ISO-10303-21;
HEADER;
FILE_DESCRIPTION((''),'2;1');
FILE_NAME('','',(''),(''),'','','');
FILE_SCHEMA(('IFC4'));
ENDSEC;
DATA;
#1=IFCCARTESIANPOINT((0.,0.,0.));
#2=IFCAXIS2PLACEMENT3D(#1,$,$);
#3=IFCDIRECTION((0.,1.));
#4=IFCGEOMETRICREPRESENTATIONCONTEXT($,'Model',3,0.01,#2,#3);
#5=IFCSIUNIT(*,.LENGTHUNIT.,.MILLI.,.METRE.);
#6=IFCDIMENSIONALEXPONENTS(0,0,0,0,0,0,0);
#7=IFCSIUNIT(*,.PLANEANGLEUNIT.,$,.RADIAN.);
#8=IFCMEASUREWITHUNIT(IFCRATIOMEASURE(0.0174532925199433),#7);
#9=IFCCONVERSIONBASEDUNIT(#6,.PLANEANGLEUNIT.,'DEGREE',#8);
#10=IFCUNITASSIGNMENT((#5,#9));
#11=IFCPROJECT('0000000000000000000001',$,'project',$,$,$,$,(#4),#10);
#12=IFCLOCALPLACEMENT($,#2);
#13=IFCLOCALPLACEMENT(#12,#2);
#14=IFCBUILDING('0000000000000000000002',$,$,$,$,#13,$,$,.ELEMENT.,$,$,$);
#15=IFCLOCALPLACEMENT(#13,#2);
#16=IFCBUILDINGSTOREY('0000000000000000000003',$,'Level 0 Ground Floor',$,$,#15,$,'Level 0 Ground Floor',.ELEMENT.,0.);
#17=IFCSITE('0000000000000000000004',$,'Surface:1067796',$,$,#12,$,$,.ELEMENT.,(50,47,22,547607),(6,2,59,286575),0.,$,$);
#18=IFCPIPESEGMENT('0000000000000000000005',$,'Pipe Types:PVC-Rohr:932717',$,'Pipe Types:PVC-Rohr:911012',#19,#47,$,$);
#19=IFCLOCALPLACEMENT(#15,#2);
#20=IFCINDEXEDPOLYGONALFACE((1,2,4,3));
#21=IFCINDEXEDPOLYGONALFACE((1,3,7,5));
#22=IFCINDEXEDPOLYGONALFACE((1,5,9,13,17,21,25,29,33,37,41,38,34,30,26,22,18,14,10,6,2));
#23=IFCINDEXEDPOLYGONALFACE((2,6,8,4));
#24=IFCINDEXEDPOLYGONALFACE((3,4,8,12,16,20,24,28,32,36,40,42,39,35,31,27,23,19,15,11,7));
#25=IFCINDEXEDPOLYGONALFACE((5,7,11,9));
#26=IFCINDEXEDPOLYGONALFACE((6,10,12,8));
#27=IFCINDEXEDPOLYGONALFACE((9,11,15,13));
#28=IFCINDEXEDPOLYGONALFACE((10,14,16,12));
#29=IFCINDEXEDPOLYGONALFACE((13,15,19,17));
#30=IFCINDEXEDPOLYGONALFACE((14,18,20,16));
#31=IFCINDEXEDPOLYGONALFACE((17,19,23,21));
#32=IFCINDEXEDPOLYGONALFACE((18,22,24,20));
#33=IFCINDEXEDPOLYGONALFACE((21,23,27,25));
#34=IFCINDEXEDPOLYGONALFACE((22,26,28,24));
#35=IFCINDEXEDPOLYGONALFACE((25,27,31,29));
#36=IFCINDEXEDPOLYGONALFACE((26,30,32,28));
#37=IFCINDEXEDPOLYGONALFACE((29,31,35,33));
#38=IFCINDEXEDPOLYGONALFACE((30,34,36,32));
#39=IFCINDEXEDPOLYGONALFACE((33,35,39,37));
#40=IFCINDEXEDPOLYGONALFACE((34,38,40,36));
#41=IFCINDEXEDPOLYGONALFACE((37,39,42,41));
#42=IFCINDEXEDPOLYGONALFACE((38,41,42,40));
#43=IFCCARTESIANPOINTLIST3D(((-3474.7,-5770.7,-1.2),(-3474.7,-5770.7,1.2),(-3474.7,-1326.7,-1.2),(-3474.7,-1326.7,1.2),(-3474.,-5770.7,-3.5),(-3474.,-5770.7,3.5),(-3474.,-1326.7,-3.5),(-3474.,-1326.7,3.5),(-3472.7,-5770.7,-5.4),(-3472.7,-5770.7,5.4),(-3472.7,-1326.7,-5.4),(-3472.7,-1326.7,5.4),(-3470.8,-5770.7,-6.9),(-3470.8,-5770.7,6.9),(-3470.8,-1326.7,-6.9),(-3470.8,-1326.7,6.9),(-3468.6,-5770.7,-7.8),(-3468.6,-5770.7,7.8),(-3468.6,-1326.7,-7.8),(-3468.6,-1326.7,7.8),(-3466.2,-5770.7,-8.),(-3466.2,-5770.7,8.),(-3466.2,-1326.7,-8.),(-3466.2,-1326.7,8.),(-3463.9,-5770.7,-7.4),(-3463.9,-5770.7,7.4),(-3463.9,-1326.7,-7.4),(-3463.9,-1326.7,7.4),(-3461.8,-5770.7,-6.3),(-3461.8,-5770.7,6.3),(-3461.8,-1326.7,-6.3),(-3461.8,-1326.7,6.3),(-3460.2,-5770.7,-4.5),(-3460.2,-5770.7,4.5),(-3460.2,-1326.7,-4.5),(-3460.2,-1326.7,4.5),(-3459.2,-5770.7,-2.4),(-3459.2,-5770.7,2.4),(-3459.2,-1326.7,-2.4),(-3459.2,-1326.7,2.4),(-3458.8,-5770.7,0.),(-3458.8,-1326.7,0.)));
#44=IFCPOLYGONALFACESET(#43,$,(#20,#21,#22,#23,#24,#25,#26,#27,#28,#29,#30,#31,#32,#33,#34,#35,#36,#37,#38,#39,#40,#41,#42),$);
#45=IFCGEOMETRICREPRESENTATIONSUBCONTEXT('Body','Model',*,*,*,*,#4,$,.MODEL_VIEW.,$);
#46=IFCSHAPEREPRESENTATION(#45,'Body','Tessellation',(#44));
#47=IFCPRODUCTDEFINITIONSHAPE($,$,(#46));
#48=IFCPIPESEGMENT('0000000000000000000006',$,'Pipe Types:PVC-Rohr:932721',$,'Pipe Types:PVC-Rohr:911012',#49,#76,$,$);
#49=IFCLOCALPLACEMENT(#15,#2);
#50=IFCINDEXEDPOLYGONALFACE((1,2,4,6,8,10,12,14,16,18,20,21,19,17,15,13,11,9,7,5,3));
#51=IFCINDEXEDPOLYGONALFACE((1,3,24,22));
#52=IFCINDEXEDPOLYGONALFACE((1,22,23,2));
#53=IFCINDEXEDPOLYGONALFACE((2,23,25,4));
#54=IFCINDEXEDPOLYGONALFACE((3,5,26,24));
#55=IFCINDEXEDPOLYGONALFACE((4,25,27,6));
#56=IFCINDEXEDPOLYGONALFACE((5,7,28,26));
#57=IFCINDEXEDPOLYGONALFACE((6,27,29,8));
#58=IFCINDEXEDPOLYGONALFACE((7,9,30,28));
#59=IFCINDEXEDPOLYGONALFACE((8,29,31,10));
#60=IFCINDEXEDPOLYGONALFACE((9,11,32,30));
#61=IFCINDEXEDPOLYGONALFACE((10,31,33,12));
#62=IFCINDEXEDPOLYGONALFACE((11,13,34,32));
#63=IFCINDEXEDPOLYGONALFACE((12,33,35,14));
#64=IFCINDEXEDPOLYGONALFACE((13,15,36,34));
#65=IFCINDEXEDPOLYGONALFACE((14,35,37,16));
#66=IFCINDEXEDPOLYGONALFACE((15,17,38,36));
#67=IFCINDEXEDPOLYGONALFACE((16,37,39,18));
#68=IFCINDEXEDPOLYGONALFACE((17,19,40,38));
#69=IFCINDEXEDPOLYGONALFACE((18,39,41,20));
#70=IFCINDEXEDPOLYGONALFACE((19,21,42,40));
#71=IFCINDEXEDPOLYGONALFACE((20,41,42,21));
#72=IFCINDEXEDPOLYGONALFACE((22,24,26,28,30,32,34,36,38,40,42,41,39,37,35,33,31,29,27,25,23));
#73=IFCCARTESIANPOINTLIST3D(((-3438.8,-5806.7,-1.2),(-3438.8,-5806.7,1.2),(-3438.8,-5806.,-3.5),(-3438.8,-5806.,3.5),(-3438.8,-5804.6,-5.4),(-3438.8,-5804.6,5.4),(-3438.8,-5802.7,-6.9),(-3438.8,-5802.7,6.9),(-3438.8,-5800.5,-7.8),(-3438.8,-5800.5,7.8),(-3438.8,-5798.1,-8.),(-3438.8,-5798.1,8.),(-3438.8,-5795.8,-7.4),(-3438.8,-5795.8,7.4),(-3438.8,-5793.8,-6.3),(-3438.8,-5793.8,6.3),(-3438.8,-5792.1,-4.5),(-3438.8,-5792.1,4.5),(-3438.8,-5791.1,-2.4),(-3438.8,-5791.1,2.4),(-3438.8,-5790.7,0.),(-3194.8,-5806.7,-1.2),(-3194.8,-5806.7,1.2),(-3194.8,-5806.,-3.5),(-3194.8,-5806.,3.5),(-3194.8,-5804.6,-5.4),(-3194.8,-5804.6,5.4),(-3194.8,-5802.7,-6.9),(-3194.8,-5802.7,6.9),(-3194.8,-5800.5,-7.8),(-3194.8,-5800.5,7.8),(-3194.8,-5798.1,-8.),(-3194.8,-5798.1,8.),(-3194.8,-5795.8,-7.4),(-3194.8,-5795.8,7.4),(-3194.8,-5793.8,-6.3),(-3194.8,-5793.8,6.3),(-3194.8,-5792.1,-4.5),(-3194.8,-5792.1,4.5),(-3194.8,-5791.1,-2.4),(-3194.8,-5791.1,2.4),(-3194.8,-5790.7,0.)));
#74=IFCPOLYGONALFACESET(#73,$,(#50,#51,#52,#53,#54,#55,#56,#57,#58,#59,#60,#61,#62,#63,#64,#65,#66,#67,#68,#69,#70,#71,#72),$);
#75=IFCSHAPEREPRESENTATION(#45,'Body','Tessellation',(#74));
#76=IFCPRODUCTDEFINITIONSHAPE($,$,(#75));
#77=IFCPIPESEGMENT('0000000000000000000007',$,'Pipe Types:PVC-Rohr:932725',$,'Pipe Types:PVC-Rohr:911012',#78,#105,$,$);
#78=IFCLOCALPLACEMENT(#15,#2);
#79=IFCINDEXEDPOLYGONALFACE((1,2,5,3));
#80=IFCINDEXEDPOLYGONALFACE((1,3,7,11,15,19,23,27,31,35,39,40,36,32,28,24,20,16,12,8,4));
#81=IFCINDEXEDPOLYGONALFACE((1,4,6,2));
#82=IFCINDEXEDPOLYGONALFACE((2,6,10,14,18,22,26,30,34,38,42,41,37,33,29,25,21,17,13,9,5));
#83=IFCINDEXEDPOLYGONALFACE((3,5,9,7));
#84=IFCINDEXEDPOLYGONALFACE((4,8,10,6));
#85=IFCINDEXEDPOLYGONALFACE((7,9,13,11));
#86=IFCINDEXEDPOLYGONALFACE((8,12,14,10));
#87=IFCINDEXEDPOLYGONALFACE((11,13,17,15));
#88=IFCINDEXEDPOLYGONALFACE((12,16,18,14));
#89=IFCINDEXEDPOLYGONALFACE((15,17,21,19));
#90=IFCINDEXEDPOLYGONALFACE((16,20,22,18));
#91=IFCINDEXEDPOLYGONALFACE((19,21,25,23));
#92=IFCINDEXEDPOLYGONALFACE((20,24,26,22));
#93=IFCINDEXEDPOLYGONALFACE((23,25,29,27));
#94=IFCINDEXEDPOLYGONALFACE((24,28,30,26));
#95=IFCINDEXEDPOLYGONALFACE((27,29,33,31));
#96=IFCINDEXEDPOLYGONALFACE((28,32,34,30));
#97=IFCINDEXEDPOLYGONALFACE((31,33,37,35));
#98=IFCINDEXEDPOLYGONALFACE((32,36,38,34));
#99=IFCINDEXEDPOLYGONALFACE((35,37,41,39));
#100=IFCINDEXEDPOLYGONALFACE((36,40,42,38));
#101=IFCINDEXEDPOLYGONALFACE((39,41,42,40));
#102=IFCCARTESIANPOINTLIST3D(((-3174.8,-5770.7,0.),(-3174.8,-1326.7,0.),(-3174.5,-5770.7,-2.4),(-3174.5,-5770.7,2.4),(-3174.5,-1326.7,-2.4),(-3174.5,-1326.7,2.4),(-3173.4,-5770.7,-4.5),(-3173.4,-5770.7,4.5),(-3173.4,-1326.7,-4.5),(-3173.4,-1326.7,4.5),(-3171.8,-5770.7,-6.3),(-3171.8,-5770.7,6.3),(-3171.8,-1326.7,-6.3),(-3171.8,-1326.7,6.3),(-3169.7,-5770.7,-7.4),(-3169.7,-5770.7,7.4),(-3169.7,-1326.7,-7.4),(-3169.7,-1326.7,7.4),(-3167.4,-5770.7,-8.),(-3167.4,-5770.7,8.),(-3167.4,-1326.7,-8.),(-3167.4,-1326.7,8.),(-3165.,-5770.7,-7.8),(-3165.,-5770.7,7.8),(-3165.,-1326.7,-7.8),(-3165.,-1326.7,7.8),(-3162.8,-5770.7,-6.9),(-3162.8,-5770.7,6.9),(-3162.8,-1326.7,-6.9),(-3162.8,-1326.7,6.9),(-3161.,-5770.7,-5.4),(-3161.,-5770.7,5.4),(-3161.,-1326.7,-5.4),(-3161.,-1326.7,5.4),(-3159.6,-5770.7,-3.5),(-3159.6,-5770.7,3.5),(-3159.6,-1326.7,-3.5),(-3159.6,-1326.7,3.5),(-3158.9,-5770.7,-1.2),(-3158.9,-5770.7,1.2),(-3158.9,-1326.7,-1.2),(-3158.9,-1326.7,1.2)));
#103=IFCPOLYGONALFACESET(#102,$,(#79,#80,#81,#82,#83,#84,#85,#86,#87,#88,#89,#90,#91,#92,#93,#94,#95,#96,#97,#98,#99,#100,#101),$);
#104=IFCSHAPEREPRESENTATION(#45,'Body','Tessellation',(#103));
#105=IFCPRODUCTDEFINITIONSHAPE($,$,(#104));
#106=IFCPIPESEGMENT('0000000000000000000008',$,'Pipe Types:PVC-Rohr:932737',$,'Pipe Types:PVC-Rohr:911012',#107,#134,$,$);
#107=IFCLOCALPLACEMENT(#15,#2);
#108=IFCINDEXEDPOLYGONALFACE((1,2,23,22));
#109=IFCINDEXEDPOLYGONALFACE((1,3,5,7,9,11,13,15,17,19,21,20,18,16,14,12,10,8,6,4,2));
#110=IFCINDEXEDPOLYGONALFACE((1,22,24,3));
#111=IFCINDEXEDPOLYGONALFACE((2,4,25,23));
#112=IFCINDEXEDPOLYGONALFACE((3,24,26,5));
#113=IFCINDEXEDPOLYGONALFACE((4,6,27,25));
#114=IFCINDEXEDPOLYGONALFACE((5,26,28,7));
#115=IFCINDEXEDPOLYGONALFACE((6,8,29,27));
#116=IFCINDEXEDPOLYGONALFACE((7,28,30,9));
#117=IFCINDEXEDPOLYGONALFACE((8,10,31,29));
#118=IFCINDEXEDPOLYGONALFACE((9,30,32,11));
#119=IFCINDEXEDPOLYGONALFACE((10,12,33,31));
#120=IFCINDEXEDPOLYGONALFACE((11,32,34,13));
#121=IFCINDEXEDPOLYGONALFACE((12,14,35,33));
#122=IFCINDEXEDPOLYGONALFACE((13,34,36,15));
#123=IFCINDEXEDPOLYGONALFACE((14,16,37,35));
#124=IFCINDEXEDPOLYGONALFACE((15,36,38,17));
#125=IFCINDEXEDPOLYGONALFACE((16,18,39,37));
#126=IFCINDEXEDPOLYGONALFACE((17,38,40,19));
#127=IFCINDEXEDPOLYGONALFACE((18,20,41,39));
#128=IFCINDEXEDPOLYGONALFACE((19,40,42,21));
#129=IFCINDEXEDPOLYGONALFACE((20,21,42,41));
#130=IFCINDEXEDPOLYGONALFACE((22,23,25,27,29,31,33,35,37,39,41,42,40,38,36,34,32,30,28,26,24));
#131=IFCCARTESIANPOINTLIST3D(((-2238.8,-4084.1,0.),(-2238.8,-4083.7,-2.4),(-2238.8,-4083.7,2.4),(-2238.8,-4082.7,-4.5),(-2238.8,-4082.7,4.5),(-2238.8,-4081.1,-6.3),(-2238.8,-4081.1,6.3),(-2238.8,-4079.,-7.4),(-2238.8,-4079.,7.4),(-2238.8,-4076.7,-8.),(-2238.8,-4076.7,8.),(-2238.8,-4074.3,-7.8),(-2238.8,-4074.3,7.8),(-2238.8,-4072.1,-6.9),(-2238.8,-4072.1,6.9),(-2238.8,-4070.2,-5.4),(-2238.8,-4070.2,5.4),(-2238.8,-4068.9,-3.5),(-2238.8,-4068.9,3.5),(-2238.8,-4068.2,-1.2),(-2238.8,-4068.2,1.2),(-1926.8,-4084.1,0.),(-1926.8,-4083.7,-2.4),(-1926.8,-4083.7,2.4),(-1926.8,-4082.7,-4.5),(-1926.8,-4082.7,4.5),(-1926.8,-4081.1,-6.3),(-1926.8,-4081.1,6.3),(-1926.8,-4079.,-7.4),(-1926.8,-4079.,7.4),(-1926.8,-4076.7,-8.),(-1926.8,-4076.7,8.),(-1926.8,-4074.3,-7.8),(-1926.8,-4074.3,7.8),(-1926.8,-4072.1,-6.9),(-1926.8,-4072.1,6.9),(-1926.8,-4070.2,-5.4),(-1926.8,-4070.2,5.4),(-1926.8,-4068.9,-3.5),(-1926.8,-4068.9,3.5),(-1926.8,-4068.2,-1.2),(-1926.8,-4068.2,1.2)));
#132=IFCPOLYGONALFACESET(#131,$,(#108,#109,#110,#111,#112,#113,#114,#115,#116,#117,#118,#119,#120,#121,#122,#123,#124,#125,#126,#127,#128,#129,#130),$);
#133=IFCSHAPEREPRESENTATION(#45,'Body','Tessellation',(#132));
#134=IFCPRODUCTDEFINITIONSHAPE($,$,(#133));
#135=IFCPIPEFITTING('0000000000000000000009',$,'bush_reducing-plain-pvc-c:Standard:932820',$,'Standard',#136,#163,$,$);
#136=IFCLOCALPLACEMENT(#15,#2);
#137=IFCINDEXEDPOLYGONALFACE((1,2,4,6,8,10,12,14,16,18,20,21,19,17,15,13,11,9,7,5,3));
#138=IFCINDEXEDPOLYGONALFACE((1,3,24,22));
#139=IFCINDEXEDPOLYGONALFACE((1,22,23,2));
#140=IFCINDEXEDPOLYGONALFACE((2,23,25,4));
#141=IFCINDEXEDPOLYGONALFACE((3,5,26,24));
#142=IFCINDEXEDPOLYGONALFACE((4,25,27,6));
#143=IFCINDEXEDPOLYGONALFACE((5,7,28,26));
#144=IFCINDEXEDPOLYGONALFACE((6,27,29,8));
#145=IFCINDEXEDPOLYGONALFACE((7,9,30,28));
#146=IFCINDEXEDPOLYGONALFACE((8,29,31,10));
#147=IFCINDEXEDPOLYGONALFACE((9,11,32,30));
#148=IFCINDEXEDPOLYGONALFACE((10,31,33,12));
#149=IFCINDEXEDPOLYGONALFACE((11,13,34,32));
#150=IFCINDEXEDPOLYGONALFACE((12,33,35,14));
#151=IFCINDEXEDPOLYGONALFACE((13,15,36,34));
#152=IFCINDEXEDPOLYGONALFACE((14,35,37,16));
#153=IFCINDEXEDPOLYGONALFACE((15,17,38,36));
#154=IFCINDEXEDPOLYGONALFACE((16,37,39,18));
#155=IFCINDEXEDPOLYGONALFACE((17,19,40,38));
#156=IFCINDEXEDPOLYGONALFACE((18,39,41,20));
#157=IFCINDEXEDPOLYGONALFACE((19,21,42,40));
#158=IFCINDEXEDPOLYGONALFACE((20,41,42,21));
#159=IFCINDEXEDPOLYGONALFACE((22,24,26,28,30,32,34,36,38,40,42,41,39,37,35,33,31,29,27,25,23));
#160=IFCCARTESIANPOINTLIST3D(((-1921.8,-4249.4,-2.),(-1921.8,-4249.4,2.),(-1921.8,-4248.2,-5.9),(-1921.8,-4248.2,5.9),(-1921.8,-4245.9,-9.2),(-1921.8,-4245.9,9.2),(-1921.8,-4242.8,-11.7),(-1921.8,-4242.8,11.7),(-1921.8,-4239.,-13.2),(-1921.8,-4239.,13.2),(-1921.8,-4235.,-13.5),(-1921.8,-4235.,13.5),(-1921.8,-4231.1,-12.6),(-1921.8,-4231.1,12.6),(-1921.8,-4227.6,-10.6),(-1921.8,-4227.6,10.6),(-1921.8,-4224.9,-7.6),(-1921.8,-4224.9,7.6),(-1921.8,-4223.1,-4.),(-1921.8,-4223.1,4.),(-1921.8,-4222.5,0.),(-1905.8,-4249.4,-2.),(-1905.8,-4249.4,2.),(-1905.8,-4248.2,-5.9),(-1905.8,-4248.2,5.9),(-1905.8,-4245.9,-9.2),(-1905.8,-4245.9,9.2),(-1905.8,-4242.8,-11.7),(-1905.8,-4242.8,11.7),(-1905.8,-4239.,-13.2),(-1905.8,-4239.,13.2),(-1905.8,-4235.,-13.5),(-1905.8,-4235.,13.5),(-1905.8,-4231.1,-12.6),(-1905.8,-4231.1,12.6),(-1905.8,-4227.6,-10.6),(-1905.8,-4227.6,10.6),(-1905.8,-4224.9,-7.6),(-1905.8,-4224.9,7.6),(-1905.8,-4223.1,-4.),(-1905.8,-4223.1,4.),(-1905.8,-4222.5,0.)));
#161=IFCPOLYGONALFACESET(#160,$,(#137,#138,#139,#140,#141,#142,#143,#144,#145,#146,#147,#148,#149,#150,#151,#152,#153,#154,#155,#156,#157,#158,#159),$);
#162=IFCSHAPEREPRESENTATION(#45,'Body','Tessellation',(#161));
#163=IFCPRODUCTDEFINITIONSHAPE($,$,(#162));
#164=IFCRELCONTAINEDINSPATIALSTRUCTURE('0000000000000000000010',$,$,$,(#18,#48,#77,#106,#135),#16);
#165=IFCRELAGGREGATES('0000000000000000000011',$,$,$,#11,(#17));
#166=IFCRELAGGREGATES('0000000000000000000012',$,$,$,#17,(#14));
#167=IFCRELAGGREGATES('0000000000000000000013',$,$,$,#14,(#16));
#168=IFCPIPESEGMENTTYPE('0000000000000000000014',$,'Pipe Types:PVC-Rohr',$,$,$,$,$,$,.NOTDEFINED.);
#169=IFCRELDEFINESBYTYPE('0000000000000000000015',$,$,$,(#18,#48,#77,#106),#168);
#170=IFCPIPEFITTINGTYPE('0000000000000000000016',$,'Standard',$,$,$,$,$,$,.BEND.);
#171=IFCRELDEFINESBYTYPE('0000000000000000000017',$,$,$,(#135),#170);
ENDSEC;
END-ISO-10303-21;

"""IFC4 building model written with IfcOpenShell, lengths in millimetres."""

from ifc_helpers import new_model, entity, si_unit, converted_unit, direction, frame, frame_2d, origin, place, context, subcontext, project, spatial, circle, extrude, source, transform, mapped, type_object, type_shapes, element, save


model = new_model("IFC4")

# Units and contexts
model_context = context("Model", 3, precision=0.01, world=origin(), true_north=direction((0.0, 1.0)))
body_context = subcontext(model_context, "Body", "Model", "MODEL_VIEW")
ifc_project = project(units=[si_unit("LENGTHUNIT", "METRE", prefix="MILLI"), converted_unit("PLANEANGLEUNIT", "DEGREE", entity("IfcRatioMeasure", 0.0174532925199433), si_unit("PLANEANGLEUNIT", "RADIAN"), dimensions=[0, 0, 0, 0, 0, 0, 0])], contexts=[model_context])

# Site, building, storey
site_placement = place(None, origin())
site = spatial("IfcSite", under=ifc_project, at=site_placement, Name="Surface:1067796", CompositionType="ELEMENT", RefLatitude=(50, 47, 22, 547607), RefLongitude=(6, 2, 59, 286575), RefElevation=0.0)
building_placement = place(site_placement, origin())
building = spatial("IfcBuilding", under=site, at=building_placement, CompositionType="ELEMENT")
storey_placement = place(building_placement, origin())
storey = spatial("IfcBuildingStorey", under=building, at=storey_placement, Name="Level 0 Ground Floor", LongName="Level 0 Ground Floor", CompositionType="ELEMENT", Elevation=0.0)

# Pipe segments
pipe_segment_type_1 = type_object("IfcPipeSegmentType", Name="Pipe Types:PVC-Rohr", PredefinedType="NOTDEFINED")
pipe_segment_1_placement = place(storey_placement, frame((-3476.4, -5770.7, -9.6)))
element("IfcPipeSegment", 1, at=pipe_segment_1_placement, inside=storey, type_object=pipe_segment_type_1, Name="Pipe Types:PVC-Rohr:932717", ObjectType="Pipe Types:PVC-Rohr:911012", context=body_context, shape_type="SweptSolid", body=[
    extrude(circle(Radius=8.0, at=frame_2d((0.0, 0.0), x_axis=(1.0, 0.0))), frame((9.6, 0.0, 9.6), z_axis=(0.0, 1.0, 0.0), x_axis=(1.0, 0.0, 0.0)), (0.0, 0.0, 1.0), 4444.0),
])
pipe_segment_2_placement = place(storey_placement, frame((-3438.8, -5808.3, -9.6)))
element("IfcPipeSegment", 2, at=pipe_segment_2_placement, inside=storey, type_object=pipe_segment_type_1, Name="Pipe Types:PVC-Rohr:932721", ObjectType="Pipe Types:PVC-Rohr:911012", context=body_context, shape_type="SweptSolid", body=[
    extrude(circle(Radius=8.0, at=frame_2d((0.0, 0.0), x_axis=(1.0, 0.0))), frame((0.0, 9.6, 9.6), z_axis=(1.0, 0.0, 0.0), x_axis=(0.0, 1.0, 0.0)), (0.0, 0.0, 1.0), 244.0),
])
pipe_segment_3_placement = place(storey_placement, frame((-3176.4, -5770.7, -9.6)))
element("IfcPipeSegment", 3, at=pipe_segment_3_placement, inside=storey, type_object=pipe_segment_type_1, Name="Pipe Types:PVC-Rohr:932725", ObjectType="Pipe Types:PVC-Rohr:911012", context=body_context, shape_type="SweptSolid", body=[
    extrude(circle(Radius=8.0, at=frame_2d((0.0, 0.0), x_axis=(1.0, 0.0))), frame((9.6, 0.0, 9.6), z_axis=(0.0, 1.0, 0.0), x_axis=(-1.0, 0.0, 0.0)), (0.0, 0.0, 1.0), 4444.0),
])
pipe_segment_4_placement = place(storey_placement, frame((-2238.8, -4085.7, -9.6)))
element("IfcPipeSegment", 4, at=pipe_segment_4_placement, inside=storey, type_object=pipe_segment_type_1, Name="Pipe Types:PVC-Rohr:932737", ObjectType="Pipe Types:PVC-Rohr:911012", context=body_context, shape_type="SweptSolid", body=[
    extrude(circle(Radius=8.0, at=frame_2d((0.0, 0.0), x_axis=(1.0, 0.0))), frame((0.0, 9.6, 9.6), z_axis=(1.0, 0.0, 0.0), x_axis=(0.0, -1.0, 0.0)), (0.0, 0.0, 1.0), 312.0),
])

# Pipe fitting
pipe_fitting_type_1 = type_object("IfcPipeFittingType", Name="Standard", PredefinedType="BEND")
shared_shape_1 = source(origin(), body_context, "Body", "SweptSolid", [
    extrude(circle(Radius=13.5, at=frame_2d((0.0, 0.0), x_axis=(1.0, 0.0))), frame((0.0, 0.0, 0.0), z_axis=(1.0, 0.0, 0.0), x_axis=(0.0, 1.0, 0.0)), (0.0, 0.0, 1.0), 16.0),
])
type_shapes(pipe_fitting_type_1, [shared_shape_1])
pipe_fitting_1_placement = place(storey_placement, frame((-1921.8, -4236.0, 0.0)))
element("IfcPipeFitting", 5, at=pipe_fitting_1_placement, inside=storey, type_object=pipe_fitting_type_1, Name="bush_reducing-plain-pvc-c:Standard:932820", ObjectType="Standard", context=body_context, shape_type="MappedRepresentation", body=[
    mapped(shared_shape_1, transform((0.0, 0.0, 0.0), scale=1.0)),
])

save(model, "model.ifc")
